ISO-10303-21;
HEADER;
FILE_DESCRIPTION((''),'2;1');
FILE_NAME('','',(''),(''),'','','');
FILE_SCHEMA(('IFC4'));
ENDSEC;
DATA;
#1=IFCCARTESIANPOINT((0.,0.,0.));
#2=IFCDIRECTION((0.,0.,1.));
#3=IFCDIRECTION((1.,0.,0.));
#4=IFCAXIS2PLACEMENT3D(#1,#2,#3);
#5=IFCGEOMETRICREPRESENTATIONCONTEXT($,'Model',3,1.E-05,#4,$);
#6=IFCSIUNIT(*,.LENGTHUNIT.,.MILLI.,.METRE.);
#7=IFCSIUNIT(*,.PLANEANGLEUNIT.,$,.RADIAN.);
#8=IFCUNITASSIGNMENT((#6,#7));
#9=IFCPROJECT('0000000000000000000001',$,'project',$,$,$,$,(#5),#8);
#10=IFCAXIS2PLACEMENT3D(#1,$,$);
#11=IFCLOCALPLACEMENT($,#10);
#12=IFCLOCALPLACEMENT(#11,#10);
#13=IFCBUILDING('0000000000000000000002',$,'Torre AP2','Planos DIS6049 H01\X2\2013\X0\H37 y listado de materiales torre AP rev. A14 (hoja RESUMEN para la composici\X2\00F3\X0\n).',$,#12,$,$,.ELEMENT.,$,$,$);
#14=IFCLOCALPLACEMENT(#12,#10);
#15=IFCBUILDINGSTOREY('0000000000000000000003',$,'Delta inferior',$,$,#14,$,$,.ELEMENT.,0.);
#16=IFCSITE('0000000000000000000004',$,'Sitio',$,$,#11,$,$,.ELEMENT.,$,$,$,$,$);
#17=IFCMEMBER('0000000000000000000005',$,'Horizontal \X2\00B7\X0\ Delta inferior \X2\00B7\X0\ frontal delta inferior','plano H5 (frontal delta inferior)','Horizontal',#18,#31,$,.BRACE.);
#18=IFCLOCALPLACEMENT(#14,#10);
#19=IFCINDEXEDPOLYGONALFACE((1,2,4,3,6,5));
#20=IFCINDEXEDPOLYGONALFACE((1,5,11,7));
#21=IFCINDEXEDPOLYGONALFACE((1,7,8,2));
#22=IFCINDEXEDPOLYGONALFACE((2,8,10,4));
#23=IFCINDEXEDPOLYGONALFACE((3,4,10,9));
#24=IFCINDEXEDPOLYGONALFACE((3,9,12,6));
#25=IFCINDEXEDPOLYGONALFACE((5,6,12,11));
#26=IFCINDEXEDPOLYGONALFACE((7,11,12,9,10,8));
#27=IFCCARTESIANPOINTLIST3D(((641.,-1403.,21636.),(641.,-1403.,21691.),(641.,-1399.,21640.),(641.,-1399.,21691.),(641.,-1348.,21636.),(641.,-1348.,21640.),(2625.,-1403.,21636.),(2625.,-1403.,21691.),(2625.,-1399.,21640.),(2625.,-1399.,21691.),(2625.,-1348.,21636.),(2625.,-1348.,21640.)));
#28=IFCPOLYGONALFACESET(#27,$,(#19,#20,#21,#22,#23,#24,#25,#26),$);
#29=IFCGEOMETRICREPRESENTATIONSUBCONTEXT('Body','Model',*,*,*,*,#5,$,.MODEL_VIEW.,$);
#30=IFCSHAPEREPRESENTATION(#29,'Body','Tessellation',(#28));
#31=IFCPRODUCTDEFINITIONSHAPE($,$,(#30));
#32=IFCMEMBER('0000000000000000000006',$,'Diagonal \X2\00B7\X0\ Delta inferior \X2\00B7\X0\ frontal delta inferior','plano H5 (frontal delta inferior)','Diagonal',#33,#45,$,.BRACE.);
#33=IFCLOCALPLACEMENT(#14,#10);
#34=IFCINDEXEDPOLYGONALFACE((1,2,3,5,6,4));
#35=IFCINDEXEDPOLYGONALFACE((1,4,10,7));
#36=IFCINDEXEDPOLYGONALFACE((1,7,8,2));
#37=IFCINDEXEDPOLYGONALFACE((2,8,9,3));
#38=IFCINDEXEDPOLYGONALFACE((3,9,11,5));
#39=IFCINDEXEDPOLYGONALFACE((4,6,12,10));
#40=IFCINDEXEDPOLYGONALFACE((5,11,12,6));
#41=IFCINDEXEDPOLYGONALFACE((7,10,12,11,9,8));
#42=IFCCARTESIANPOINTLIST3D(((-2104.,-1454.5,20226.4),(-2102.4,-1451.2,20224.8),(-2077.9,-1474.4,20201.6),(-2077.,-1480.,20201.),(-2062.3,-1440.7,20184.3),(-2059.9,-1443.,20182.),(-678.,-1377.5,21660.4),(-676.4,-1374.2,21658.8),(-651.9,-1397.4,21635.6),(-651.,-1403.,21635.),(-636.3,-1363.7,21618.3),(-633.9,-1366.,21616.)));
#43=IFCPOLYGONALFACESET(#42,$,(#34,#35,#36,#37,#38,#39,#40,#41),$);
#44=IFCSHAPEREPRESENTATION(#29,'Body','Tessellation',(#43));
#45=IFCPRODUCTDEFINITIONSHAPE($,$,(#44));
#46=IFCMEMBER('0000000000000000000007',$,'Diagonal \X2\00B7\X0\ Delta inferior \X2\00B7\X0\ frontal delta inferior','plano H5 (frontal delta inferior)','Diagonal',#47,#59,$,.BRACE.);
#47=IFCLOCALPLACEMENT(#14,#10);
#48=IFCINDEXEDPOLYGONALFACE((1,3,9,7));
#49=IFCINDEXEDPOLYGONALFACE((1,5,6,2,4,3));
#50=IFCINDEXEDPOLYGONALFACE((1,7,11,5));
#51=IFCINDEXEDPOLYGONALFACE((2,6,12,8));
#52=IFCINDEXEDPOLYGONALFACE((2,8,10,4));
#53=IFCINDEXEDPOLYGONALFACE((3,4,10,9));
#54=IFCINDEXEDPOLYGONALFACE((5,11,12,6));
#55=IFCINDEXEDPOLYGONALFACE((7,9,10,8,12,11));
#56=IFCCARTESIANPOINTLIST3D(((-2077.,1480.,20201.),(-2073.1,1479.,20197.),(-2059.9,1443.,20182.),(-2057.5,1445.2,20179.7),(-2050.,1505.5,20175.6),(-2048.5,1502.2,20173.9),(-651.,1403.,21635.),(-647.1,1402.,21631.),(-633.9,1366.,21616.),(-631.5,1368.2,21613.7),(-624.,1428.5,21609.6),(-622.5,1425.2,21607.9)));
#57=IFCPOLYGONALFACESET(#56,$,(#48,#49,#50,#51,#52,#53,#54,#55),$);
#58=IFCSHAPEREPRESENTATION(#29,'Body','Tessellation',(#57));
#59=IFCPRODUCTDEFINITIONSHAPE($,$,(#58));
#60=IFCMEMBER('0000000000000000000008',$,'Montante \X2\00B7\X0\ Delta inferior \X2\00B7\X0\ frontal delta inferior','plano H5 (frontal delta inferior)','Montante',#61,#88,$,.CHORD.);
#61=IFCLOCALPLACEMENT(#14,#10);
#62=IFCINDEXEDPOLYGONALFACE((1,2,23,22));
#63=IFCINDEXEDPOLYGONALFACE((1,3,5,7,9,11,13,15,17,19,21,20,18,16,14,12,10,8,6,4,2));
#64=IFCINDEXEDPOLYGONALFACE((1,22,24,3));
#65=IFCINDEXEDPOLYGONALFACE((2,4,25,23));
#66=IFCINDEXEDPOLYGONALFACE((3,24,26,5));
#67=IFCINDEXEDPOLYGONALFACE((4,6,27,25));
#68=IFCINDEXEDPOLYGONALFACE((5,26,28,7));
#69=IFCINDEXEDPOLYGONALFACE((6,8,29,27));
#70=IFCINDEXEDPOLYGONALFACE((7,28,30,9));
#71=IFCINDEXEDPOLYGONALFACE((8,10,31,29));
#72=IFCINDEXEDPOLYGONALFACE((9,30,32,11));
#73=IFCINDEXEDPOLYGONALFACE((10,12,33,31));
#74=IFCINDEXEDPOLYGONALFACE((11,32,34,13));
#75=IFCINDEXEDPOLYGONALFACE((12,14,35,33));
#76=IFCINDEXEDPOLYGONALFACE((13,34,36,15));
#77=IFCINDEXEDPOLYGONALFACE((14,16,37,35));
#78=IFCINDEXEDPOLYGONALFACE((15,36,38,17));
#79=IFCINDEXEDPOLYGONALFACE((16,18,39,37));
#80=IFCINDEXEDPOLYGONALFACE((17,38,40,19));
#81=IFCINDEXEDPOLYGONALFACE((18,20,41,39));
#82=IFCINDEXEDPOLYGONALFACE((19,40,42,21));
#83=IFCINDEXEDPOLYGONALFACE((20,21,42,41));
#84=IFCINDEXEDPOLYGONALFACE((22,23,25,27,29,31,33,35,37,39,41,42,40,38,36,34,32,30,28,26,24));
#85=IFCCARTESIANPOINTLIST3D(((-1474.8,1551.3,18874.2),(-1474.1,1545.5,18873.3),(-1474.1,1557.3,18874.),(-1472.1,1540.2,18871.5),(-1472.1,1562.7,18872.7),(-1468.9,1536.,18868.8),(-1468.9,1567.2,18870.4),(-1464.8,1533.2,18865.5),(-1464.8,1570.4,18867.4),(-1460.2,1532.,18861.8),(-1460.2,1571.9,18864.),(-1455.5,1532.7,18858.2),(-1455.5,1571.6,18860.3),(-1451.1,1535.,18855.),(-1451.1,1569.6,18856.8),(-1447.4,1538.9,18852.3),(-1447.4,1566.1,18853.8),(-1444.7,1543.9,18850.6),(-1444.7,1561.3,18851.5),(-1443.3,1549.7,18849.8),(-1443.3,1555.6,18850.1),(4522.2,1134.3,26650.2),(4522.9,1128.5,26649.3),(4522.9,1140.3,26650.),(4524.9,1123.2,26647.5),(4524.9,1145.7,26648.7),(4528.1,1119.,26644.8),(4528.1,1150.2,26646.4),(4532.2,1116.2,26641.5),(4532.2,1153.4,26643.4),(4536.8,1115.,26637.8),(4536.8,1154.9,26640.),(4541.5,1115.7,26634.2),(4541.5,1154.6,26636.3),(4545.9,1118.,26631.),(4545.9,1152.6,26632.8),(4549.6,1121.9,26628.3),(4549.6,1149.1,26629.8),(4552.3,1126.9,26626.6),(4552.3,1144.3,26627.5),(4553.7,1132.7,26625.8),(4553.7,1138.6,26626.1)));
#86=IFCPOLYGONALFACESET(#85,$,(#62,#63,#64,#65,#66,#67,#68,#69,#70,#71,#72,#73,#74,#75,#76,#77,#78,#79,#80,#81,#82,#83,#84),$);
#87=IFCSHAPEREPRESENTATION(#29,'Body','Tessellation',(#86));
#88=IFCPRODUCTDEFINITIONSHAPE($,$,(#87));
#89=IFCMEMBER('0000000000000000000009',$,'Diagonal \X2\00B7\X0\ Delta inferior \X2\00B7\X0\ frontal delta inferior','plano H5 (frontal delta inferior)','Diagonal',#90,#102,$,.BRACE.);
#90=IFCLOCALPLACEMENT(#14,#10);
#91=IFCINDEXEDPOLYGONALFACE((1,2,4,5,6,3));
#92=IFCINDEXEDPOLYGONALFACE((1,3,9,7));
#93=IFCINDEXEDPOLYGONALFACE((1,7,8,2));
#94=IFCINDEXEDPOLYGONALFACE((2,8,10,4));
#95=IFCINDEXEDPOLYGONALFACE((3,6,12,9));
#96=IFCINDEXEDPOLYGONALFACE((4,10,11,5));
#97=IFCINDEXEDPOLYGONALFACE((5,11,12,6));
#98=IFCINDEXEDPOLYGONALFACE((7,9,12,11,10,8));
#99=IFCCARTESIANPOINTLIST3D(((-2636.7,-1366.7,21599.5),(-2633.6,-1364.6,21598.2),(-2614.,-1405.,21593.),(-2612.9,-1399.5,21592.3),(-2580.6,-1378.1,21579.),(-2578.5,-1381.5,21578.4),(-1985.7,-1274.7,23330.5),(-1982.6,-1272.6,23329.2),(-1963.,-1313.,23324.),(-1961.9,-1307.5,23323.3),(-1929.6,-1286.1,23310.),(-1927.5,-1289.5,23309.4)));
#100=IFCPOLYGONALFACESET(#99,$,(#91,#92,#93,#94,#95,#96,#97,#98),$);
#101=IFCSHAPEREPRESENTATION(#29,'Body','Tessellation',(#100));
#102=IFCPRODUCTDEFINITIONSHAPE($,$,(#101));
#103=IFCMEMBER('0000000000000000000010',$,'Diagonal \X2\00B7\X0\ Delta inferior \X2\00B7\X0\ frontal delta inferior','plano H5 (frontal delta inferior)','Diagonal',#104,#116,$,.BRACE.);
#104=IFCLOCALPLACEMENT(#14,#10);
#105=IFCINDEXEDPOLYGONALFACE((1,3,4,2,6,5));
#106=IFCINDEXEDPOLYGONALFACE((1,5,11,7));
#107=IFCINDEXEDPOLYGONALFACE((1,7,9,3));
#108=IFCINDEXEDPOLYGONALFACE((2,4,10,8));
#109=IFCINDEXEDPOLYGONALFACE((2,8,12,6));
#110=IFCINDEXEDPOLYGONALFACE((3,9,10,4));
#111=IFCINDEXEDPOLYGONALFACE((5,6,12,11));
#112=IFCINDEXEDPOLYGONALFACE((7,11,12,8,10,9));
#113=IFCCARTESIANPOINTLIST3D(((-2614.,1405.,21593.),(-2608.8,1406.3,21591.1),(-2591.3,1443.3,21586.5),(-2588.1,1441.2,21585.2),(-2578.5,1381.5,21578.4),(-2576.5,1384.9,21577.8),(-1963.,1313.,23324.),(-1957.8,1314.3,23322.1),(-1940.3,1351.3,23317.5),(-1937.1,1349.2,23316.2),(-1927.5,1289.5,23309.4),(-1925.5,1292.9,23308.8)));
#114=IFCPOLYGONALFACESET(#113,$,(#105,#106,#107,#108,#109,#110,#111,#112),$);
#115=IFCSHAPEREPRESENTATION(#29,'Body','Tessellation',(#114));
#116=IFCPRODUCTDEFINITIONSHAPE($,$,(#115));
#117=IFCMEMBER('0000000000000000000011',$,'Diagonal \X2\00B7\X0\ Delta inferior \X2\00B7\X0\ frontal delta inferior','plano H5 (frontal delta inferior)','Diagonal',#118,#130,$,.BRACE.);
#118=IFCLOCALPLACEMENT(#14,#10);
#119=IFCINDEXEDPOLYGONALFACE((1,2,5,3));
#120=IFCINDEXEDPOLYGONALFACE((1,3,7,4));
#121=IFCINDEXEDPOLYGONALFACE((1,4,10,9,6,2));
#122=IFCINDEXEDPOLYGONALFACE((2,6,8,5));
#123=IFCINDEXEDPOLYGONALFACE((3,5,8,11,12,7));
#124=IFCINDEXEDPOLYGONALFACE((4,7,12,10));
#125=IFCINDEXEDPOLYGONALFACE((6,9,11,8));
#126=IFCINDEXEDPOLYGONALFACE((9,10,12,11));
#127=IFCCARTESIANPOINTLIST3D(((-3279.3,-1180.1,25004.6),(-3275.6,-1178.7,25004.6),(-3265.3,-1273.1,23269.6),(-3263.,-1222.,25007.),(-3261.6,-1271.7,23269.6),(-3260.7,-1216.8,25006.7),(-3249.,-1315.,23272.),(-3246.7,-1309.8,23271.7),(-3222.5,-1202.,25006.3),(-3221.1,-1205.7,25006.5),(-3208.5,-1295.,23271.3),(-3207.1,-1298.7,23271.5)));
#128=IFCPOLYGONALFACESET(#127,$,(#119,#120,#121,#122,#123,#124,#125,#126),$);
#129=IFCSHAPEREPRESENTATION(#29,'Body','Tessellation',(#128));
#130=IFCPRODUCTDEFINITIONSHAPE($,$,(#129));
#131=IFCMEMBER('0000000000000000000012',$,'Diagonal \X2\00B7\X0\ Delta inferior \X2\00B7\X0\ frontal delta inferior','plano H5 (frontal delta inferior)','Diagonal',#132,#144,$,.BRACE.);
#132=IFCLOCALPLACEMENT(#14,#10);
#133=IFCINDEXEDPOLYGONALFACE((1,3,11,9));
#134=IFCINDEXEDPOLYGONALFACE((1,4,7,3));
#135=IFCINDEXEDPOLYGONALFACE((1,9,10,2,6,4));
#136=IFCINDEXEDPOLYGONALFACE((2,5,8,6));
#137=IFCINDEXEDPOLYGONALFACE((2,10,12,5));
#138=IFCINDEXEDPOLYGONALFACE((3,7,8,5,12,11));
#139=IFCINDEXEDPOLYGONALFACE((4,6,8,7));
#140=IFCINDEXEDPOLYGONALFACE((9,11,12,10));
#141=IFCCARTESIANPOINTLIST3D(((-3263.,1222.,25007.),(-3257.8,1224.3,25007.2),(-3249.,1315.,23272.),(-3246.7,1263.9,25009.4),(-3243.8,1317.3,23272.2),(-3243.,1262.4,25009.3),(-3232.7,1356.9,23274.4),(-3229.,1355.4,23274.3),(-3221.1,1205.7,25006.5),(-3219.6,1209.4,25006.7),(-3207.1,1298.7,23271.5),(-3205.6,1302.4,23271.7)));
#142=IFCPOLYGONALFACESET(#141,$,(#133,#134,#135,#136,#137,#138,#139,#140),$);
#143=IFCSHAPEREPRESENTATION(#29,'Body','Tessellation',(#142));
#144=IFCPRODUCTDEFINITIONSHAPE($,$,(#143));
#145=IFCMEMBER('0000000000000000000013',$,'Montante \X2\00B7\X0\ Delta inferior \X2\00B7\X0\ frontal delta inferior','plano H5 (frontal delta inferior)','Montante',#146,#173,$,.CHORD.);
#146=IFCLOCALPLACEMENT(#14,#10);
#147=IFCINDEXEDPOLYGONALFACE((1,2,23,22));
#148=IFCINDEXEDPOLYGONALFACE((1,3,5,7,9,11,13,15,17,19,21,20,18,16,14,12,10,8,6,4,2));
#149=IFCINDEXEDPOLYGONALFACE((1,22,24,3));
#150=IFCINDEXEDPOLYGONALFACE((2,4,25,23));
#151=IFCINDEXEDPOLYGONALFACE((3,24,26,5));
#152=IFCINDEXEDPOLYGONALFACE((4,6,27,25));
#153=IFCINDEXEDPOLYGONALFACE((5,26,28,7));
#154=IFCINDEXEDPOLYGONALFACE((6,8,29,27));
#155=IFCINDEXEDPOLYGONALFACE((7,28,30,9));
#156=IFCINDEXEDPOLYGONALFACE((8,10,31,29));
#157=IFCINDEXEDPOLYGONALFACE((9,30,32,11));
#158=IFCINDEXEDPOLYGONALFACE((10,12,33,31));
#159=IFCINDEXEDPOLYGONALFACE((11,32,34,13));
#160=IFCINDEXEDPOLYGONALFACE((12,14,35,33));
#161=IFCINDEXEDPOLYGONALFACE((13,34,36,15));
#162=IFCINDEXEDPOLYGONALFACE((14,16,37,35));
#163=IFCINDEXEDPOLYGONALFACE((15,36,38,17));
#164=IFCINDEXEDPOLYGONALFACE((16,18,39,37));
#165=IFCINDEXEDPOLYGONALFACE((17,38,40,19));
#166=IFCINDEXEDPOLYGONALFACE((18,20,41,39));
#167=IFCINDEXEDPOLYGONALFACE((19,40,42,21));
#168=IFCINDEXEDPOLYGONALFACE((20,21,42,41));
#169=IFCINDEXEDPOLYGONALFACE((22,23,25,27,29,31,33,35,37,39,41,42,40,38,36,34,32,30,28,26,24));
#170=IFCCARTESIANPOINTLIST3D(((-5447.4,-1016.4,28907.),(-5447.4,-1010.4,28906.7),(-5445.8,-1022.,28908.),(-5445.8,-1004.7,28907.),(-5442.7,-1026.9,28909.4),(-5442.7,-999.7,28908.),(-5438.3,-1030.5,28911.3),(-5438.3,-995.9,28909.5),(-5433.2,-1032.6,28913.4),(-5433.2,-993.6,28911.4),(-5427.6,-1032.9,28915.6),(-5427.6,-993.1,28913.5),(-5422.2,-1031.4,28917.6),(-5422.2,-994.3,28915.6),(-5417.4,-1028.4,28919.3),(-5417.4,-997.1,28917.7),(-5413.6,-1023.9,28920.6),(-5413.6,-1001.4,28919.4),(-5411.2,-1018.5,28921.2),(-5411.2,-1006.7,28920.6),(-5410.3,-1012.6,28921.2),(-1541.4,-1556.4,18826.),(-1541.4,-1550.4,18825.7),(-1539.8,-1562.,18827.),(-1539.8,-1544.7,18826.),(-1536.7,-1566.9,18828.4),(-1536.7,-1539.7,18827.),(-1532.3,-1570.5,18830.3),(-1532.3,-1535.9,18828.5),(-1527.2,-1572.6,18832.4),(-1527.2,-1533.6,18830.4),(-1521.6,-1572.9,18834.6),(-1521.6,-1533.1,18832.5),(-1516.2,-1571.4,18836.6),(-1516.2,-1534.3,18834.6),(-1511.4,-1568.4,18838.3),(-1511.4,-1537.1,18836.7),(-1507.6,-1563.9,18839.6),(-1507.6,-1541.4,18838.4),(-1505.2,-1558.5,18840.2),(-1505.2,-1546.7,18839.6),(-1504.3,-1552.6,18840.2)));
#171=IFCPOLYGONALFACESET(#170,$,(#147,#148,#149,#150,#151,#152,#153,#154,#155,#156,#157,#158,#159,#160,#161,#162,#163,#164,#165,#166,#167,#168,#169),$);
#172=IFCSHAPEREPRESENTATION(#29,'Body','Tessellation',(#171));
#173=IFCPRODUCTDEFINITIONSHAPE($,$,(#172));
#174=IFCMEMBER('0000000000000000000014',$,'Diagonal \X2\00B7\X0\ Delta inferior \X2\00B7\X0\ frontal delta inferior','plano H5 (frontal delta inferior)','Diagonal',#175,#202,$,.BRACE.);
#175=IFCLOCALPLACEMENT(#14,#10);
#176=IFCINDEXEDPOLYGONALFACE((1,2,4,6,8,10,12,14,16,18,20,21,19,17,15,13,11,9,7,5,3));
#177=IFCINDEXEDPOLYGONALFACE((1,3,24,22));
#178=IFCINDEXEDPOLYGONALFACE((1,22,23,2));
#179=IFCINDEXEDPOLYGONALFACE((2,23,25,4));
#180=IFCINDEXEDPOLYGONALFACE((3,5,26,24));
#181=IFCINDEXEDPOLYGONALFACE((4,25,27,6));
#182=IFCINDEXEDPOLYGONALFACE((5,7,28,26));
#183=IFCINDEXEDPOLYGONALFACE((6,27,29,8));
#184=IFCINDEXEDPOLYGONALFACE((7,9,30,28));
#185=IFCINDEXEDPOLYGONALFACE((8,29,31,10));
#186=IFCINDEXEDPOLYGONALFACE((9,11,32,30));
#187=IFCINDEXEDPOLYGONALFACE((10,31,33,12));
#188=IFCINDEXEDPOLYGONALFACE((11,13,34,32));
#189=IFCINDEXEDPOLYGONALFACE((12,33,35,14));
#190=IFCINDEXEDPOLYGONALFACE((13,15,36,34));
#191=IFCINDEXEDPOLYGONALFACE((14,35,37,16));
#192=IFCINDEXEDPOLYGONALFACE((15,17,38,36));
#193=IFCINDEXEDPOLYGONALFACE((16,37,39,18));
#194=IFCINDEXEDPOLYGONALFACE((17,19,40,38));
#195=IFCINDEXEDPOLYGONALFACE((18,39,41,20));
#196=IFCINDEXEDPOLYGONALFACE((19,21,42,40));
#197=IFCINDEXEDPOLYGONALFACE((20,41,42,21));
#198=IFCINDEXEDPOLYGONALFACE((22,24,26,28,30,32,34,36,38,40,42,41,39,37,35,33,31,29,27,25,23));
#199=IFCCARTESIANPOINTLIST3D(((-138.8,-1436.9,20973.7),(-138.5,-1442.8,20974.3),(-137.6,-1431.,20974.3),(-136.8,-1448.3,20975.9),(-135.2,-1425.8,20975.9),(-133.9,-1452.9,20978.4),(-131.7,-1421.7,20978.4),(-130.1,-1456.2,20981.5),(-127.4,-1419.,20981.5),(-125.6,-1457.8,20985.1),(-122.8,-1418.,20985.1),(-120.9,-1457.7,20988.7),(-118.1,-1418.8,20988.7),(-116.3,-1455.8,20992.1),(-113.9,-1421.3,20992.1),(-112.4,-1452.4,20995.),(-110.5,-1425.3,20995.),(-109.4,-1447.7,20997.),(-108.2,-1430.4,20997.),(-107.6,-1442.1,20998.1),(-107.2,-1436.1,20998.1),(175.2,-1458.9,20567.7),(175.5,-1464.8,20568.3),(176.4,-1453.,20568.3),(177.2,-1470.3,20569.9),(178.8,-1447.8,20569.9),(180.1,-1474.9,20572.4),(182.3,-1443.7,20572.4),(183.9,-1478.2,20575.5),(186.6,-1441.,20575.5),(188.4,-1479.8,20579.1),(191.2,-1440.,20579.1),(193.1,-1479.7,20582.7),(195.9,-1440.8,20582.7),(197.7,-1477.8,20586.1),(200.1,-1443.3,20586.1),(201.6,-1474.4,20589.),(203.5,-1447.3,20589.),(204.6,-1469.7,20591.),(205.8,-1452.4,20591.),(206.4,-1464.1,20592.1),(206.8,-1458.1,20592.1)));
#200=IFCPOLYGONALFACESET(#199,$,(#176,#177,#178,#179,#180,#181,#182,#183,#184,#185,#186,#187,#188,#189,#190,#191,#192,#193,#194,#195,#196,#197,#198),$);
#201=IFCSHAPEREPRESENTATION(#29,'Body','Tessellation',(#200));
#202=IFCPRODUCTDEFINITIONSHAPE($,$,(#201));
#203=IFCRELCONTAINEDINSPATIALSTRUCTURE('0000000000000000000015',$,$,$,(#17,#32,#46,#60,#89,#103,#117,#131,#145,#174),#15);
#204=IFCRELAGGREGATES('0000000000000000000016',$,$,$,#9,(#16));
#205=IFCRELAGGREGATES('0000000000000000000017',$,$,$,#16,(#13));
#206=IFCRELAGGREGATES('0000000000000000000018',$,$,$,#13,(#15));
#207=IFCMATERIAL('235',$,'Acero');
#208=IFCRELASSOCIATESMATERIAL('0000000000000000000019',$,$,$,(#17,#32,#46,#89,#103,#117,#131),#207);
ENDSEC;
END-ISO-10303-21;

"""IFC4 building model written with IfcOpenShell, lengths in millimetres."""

from ifc_helpers import new_model, si_unit, frame, frame_2d, origin, origin_with_axes, place, context, subcontext, project, spatial, circle, l_section, extrude, material, element, save


model = new_model("IFC4")

# Units and contexts
model_context = context("Model", 3, precision=1e-05, world=origin_with_axes())
body_context = subcontext(model_context, "Body", "Model", "MODEL_VIEW")
ifc_project = project(units=[si_unit("LENGTHUNIT", "METRE", prefix="MILLI"), si_unit("PLANEANGLEUNIT", "RADIAN")], contexts=[model_context])

# Site, building, storey
site_placement = place(None, origin())
site = spatial("IfcSite", under=ifc_project, at=site_placement, Name="Sitio", CompositionType="ELEMENT")
building_placement = place(site_placement, origin())
building = spatial("IfcBuilding", under=site, at=building_placement, Name="Torre AP2", Description="Planos DIS6049 H01–H37 y listado de materiales torre AP rev. A14 (hoja RESUMEN para la composición).", CompositionType="ELEMENT")
storey_placement = place(building_placement, origin())
storey = spatial("IfcBuildingStorey", under=building, at=storey_placement, Name="Delta inferior", CompositionType="ELEMENT", Elevation=0.0)

# Members
ifc_material_1 = material(Name="235", Category="Acero")
member_1_placement = place(storey_placement, frame((641.0, -1403.0, 21636.0), z_axis=(1.0, 0.0, 0.0), x_axis=(0.0, 1.0, 0.0)))
element("IfcMember", 1, at=member_1_placement, inside=storey, material=ifc_material_1, Name="Horizontal · Delta inferior · frontal delta inferior", Description="plano H5 (frontal delta inferior)", ObjectType="Horizontal", PredefinedType="BRACE", context=body_context, shape_type="SweptSolid", body=[
    extrude(l_section(Depth=55.0, Width=55.0, Thickness=4.0, at=frame_2d((27.5, 27.5))), None, (0.0, 0.0, 1.0), 1984.0),
])
for number, where, z_axis, x_axis, name in (
    (2, (-2077.0, -1480.0, 20201.0), (0.704616, 0.038047, 0.708569), (0.380197, 0.822889, -0.422261), "Diagonal · Delta inferior · frontal delta inferior"),
    (3, (-2077.0, 1480.0, 20201.0), (0.704616, -0.038047, 0.708569), (0.380197, -0.822889, -0.422261), "Diagonal · Delta inferior · frontal delta inferior"),
):
    element("IfcMember", number, at=place(storey_placement, frame(where, z_axis=z_axis, x_axis=x_axis)), inside=storey, material=ifc_material_1, Name=name, Description="plano H5 (frontal delta inferior)", ObjectType="Diagonal", PredefinedType="BRACE", context=body_context, shape_type="SweptSolid", body=[
        extrude(l_section(Depth=45.0, Width=45.0, Thickness=4.0, at=frame_2d((22.5, 22.5))), None, (0.0, 0.0, 1.0), 2023.8),
    ])
for number, where, z_axis, x_axis, name in (
    (4, (-1459.0, 1552.0, 18862.0), (0.61015, -0.042427, 0.791149), (-0.792286, -0.032673, 0.609274), "Montante · Delta inferior · frontal delta inferior"),
):
    element("IfcMember", number, at=place(storey_placement, frame(where, z_axis=z_axis, x_axis=x_axis)), inside=storey, Name=name, Description="plano H5 (frontal delta inferior)", ObjectType="Montante", PredefinedType="CHORD", context=body_context, shape_type="SweptSolid", body=[
        extrude(circle(Radius=20.0), None, (0.0, 0.0, 1.0), 9828.7),
    ])
for number, where, z_axis, x_axis, name in (
    (5, (-2614.0, -1405.0, 21593.0), (0.351577, 0.049685, 0.934839), (0.788131, 0.523198, -0.32421), "Diagonal · Delta inferior · frontal delta inferior"),
    (6, (-2614.0, 1405.0, 21593.0), (0.351577, -0.049685, 0.934839), (0.788131, -0.523198, -0.32421), "Diagonal · Delta inferior · frontal delta inferior"),
):
    element("IfcMember", number, at=place(storey_placement, frame(where, z_axis=z_axis, x_axis=x_axis)), inside=storey, material=ifc_material_1, Name=name, Description="plano H5 (frontal delta inferior)", ObjectType="Diagonal", PredefinedType="BRACE", context=body_context, shape_type="SweptSolid", body=[
        extrude(l_section(Depth=45.0, Width=45.0, Thickness=4.0, at=frame_2d((22.5, 22.5))), None, (0.0, 0.0, 1.0), 1851.7),
    ])
for number, where, z_axis, x_axis, name in (
    (7, (-3249.0, -1315.0, 23272.0), (-0.008057, 0.053524, 0.998534), (0.931947, 0.3624, -0.011905), "Diagonal · Delta inferior · frontal delta inferior"),
    (8, (-3249.0, 1315.0, 23272.0), (-0.008057, -0.053524, 0.998534), (0.931947, -0.3624, -0.011905), "Diagonal · Delta inferior · frontal delta inferior"),
):
    element("IfcMember", number, at=place(storey_placement, frame(where, z_axis=z_axis, x_axis=x_axis)), inside=storey, material=ifc_material_1, Name=name, Description="plano H5 (frontal delta inferior)", ObjectType="Diagonal", PredefinedType="BRACE", context=body_context, shape_type="SweptSolid", body=[
        extrude(l_section(Depth=45.0, Width=45.0, Thickness=4.0, at=frame_2d((22.5, 22.5))), None, (0.0, 0.0, 1.0), 1737.5),
    ])
for number, where, z_axis, x_axis, name in (
    (9, (-1523.0, -1553.0, 18833.0), (-0.36084, 0.049886, 0.931293), (0.932628, 0.019301, 0.360324), "Montante · Delta inferior · frontal delta inferior"),
):
    element("IfcMember", number, at=place(storey_placement, frame(where, z_axis=z_axis, x_axis=x_axis)), inside=storey, Name=name, Description="plano H5 (frontal delta inferior)", ObjectType="Montante", PredefinedType="CHORD", context=body_context, shape_type="SweptSolid", body=[
        extrude(circle(Radius=20.0), None, (0.0, 0.0, 1.0), 10824.7),
    ])
for number, where, z_axis, x_axis, name in (
    (10, (191.0, -1460.0, 20580.0), (-0.611219, 0.042824, 0.790302), (0.011492, 0.99891, -0.04524), "Diagonal · Delta inferior · frontal delta inferior"),
):
    element("IfcMember", number, at=place(storey_placement, frame(where, z_axis=z_axis, x_axis=x_axis)), inside=storey, Name=name, Description="plano H5 (frontal delta inferior)", ObjectType="Diagonal", PredefinedType="BRACE", context=body_context, shape_type="SweptSolid", body=[
        extrude(circle(Radius=20.0), None, (0.0, 0.0, 1.0), 513.7),
    ])

save(model, "model.ifc")
